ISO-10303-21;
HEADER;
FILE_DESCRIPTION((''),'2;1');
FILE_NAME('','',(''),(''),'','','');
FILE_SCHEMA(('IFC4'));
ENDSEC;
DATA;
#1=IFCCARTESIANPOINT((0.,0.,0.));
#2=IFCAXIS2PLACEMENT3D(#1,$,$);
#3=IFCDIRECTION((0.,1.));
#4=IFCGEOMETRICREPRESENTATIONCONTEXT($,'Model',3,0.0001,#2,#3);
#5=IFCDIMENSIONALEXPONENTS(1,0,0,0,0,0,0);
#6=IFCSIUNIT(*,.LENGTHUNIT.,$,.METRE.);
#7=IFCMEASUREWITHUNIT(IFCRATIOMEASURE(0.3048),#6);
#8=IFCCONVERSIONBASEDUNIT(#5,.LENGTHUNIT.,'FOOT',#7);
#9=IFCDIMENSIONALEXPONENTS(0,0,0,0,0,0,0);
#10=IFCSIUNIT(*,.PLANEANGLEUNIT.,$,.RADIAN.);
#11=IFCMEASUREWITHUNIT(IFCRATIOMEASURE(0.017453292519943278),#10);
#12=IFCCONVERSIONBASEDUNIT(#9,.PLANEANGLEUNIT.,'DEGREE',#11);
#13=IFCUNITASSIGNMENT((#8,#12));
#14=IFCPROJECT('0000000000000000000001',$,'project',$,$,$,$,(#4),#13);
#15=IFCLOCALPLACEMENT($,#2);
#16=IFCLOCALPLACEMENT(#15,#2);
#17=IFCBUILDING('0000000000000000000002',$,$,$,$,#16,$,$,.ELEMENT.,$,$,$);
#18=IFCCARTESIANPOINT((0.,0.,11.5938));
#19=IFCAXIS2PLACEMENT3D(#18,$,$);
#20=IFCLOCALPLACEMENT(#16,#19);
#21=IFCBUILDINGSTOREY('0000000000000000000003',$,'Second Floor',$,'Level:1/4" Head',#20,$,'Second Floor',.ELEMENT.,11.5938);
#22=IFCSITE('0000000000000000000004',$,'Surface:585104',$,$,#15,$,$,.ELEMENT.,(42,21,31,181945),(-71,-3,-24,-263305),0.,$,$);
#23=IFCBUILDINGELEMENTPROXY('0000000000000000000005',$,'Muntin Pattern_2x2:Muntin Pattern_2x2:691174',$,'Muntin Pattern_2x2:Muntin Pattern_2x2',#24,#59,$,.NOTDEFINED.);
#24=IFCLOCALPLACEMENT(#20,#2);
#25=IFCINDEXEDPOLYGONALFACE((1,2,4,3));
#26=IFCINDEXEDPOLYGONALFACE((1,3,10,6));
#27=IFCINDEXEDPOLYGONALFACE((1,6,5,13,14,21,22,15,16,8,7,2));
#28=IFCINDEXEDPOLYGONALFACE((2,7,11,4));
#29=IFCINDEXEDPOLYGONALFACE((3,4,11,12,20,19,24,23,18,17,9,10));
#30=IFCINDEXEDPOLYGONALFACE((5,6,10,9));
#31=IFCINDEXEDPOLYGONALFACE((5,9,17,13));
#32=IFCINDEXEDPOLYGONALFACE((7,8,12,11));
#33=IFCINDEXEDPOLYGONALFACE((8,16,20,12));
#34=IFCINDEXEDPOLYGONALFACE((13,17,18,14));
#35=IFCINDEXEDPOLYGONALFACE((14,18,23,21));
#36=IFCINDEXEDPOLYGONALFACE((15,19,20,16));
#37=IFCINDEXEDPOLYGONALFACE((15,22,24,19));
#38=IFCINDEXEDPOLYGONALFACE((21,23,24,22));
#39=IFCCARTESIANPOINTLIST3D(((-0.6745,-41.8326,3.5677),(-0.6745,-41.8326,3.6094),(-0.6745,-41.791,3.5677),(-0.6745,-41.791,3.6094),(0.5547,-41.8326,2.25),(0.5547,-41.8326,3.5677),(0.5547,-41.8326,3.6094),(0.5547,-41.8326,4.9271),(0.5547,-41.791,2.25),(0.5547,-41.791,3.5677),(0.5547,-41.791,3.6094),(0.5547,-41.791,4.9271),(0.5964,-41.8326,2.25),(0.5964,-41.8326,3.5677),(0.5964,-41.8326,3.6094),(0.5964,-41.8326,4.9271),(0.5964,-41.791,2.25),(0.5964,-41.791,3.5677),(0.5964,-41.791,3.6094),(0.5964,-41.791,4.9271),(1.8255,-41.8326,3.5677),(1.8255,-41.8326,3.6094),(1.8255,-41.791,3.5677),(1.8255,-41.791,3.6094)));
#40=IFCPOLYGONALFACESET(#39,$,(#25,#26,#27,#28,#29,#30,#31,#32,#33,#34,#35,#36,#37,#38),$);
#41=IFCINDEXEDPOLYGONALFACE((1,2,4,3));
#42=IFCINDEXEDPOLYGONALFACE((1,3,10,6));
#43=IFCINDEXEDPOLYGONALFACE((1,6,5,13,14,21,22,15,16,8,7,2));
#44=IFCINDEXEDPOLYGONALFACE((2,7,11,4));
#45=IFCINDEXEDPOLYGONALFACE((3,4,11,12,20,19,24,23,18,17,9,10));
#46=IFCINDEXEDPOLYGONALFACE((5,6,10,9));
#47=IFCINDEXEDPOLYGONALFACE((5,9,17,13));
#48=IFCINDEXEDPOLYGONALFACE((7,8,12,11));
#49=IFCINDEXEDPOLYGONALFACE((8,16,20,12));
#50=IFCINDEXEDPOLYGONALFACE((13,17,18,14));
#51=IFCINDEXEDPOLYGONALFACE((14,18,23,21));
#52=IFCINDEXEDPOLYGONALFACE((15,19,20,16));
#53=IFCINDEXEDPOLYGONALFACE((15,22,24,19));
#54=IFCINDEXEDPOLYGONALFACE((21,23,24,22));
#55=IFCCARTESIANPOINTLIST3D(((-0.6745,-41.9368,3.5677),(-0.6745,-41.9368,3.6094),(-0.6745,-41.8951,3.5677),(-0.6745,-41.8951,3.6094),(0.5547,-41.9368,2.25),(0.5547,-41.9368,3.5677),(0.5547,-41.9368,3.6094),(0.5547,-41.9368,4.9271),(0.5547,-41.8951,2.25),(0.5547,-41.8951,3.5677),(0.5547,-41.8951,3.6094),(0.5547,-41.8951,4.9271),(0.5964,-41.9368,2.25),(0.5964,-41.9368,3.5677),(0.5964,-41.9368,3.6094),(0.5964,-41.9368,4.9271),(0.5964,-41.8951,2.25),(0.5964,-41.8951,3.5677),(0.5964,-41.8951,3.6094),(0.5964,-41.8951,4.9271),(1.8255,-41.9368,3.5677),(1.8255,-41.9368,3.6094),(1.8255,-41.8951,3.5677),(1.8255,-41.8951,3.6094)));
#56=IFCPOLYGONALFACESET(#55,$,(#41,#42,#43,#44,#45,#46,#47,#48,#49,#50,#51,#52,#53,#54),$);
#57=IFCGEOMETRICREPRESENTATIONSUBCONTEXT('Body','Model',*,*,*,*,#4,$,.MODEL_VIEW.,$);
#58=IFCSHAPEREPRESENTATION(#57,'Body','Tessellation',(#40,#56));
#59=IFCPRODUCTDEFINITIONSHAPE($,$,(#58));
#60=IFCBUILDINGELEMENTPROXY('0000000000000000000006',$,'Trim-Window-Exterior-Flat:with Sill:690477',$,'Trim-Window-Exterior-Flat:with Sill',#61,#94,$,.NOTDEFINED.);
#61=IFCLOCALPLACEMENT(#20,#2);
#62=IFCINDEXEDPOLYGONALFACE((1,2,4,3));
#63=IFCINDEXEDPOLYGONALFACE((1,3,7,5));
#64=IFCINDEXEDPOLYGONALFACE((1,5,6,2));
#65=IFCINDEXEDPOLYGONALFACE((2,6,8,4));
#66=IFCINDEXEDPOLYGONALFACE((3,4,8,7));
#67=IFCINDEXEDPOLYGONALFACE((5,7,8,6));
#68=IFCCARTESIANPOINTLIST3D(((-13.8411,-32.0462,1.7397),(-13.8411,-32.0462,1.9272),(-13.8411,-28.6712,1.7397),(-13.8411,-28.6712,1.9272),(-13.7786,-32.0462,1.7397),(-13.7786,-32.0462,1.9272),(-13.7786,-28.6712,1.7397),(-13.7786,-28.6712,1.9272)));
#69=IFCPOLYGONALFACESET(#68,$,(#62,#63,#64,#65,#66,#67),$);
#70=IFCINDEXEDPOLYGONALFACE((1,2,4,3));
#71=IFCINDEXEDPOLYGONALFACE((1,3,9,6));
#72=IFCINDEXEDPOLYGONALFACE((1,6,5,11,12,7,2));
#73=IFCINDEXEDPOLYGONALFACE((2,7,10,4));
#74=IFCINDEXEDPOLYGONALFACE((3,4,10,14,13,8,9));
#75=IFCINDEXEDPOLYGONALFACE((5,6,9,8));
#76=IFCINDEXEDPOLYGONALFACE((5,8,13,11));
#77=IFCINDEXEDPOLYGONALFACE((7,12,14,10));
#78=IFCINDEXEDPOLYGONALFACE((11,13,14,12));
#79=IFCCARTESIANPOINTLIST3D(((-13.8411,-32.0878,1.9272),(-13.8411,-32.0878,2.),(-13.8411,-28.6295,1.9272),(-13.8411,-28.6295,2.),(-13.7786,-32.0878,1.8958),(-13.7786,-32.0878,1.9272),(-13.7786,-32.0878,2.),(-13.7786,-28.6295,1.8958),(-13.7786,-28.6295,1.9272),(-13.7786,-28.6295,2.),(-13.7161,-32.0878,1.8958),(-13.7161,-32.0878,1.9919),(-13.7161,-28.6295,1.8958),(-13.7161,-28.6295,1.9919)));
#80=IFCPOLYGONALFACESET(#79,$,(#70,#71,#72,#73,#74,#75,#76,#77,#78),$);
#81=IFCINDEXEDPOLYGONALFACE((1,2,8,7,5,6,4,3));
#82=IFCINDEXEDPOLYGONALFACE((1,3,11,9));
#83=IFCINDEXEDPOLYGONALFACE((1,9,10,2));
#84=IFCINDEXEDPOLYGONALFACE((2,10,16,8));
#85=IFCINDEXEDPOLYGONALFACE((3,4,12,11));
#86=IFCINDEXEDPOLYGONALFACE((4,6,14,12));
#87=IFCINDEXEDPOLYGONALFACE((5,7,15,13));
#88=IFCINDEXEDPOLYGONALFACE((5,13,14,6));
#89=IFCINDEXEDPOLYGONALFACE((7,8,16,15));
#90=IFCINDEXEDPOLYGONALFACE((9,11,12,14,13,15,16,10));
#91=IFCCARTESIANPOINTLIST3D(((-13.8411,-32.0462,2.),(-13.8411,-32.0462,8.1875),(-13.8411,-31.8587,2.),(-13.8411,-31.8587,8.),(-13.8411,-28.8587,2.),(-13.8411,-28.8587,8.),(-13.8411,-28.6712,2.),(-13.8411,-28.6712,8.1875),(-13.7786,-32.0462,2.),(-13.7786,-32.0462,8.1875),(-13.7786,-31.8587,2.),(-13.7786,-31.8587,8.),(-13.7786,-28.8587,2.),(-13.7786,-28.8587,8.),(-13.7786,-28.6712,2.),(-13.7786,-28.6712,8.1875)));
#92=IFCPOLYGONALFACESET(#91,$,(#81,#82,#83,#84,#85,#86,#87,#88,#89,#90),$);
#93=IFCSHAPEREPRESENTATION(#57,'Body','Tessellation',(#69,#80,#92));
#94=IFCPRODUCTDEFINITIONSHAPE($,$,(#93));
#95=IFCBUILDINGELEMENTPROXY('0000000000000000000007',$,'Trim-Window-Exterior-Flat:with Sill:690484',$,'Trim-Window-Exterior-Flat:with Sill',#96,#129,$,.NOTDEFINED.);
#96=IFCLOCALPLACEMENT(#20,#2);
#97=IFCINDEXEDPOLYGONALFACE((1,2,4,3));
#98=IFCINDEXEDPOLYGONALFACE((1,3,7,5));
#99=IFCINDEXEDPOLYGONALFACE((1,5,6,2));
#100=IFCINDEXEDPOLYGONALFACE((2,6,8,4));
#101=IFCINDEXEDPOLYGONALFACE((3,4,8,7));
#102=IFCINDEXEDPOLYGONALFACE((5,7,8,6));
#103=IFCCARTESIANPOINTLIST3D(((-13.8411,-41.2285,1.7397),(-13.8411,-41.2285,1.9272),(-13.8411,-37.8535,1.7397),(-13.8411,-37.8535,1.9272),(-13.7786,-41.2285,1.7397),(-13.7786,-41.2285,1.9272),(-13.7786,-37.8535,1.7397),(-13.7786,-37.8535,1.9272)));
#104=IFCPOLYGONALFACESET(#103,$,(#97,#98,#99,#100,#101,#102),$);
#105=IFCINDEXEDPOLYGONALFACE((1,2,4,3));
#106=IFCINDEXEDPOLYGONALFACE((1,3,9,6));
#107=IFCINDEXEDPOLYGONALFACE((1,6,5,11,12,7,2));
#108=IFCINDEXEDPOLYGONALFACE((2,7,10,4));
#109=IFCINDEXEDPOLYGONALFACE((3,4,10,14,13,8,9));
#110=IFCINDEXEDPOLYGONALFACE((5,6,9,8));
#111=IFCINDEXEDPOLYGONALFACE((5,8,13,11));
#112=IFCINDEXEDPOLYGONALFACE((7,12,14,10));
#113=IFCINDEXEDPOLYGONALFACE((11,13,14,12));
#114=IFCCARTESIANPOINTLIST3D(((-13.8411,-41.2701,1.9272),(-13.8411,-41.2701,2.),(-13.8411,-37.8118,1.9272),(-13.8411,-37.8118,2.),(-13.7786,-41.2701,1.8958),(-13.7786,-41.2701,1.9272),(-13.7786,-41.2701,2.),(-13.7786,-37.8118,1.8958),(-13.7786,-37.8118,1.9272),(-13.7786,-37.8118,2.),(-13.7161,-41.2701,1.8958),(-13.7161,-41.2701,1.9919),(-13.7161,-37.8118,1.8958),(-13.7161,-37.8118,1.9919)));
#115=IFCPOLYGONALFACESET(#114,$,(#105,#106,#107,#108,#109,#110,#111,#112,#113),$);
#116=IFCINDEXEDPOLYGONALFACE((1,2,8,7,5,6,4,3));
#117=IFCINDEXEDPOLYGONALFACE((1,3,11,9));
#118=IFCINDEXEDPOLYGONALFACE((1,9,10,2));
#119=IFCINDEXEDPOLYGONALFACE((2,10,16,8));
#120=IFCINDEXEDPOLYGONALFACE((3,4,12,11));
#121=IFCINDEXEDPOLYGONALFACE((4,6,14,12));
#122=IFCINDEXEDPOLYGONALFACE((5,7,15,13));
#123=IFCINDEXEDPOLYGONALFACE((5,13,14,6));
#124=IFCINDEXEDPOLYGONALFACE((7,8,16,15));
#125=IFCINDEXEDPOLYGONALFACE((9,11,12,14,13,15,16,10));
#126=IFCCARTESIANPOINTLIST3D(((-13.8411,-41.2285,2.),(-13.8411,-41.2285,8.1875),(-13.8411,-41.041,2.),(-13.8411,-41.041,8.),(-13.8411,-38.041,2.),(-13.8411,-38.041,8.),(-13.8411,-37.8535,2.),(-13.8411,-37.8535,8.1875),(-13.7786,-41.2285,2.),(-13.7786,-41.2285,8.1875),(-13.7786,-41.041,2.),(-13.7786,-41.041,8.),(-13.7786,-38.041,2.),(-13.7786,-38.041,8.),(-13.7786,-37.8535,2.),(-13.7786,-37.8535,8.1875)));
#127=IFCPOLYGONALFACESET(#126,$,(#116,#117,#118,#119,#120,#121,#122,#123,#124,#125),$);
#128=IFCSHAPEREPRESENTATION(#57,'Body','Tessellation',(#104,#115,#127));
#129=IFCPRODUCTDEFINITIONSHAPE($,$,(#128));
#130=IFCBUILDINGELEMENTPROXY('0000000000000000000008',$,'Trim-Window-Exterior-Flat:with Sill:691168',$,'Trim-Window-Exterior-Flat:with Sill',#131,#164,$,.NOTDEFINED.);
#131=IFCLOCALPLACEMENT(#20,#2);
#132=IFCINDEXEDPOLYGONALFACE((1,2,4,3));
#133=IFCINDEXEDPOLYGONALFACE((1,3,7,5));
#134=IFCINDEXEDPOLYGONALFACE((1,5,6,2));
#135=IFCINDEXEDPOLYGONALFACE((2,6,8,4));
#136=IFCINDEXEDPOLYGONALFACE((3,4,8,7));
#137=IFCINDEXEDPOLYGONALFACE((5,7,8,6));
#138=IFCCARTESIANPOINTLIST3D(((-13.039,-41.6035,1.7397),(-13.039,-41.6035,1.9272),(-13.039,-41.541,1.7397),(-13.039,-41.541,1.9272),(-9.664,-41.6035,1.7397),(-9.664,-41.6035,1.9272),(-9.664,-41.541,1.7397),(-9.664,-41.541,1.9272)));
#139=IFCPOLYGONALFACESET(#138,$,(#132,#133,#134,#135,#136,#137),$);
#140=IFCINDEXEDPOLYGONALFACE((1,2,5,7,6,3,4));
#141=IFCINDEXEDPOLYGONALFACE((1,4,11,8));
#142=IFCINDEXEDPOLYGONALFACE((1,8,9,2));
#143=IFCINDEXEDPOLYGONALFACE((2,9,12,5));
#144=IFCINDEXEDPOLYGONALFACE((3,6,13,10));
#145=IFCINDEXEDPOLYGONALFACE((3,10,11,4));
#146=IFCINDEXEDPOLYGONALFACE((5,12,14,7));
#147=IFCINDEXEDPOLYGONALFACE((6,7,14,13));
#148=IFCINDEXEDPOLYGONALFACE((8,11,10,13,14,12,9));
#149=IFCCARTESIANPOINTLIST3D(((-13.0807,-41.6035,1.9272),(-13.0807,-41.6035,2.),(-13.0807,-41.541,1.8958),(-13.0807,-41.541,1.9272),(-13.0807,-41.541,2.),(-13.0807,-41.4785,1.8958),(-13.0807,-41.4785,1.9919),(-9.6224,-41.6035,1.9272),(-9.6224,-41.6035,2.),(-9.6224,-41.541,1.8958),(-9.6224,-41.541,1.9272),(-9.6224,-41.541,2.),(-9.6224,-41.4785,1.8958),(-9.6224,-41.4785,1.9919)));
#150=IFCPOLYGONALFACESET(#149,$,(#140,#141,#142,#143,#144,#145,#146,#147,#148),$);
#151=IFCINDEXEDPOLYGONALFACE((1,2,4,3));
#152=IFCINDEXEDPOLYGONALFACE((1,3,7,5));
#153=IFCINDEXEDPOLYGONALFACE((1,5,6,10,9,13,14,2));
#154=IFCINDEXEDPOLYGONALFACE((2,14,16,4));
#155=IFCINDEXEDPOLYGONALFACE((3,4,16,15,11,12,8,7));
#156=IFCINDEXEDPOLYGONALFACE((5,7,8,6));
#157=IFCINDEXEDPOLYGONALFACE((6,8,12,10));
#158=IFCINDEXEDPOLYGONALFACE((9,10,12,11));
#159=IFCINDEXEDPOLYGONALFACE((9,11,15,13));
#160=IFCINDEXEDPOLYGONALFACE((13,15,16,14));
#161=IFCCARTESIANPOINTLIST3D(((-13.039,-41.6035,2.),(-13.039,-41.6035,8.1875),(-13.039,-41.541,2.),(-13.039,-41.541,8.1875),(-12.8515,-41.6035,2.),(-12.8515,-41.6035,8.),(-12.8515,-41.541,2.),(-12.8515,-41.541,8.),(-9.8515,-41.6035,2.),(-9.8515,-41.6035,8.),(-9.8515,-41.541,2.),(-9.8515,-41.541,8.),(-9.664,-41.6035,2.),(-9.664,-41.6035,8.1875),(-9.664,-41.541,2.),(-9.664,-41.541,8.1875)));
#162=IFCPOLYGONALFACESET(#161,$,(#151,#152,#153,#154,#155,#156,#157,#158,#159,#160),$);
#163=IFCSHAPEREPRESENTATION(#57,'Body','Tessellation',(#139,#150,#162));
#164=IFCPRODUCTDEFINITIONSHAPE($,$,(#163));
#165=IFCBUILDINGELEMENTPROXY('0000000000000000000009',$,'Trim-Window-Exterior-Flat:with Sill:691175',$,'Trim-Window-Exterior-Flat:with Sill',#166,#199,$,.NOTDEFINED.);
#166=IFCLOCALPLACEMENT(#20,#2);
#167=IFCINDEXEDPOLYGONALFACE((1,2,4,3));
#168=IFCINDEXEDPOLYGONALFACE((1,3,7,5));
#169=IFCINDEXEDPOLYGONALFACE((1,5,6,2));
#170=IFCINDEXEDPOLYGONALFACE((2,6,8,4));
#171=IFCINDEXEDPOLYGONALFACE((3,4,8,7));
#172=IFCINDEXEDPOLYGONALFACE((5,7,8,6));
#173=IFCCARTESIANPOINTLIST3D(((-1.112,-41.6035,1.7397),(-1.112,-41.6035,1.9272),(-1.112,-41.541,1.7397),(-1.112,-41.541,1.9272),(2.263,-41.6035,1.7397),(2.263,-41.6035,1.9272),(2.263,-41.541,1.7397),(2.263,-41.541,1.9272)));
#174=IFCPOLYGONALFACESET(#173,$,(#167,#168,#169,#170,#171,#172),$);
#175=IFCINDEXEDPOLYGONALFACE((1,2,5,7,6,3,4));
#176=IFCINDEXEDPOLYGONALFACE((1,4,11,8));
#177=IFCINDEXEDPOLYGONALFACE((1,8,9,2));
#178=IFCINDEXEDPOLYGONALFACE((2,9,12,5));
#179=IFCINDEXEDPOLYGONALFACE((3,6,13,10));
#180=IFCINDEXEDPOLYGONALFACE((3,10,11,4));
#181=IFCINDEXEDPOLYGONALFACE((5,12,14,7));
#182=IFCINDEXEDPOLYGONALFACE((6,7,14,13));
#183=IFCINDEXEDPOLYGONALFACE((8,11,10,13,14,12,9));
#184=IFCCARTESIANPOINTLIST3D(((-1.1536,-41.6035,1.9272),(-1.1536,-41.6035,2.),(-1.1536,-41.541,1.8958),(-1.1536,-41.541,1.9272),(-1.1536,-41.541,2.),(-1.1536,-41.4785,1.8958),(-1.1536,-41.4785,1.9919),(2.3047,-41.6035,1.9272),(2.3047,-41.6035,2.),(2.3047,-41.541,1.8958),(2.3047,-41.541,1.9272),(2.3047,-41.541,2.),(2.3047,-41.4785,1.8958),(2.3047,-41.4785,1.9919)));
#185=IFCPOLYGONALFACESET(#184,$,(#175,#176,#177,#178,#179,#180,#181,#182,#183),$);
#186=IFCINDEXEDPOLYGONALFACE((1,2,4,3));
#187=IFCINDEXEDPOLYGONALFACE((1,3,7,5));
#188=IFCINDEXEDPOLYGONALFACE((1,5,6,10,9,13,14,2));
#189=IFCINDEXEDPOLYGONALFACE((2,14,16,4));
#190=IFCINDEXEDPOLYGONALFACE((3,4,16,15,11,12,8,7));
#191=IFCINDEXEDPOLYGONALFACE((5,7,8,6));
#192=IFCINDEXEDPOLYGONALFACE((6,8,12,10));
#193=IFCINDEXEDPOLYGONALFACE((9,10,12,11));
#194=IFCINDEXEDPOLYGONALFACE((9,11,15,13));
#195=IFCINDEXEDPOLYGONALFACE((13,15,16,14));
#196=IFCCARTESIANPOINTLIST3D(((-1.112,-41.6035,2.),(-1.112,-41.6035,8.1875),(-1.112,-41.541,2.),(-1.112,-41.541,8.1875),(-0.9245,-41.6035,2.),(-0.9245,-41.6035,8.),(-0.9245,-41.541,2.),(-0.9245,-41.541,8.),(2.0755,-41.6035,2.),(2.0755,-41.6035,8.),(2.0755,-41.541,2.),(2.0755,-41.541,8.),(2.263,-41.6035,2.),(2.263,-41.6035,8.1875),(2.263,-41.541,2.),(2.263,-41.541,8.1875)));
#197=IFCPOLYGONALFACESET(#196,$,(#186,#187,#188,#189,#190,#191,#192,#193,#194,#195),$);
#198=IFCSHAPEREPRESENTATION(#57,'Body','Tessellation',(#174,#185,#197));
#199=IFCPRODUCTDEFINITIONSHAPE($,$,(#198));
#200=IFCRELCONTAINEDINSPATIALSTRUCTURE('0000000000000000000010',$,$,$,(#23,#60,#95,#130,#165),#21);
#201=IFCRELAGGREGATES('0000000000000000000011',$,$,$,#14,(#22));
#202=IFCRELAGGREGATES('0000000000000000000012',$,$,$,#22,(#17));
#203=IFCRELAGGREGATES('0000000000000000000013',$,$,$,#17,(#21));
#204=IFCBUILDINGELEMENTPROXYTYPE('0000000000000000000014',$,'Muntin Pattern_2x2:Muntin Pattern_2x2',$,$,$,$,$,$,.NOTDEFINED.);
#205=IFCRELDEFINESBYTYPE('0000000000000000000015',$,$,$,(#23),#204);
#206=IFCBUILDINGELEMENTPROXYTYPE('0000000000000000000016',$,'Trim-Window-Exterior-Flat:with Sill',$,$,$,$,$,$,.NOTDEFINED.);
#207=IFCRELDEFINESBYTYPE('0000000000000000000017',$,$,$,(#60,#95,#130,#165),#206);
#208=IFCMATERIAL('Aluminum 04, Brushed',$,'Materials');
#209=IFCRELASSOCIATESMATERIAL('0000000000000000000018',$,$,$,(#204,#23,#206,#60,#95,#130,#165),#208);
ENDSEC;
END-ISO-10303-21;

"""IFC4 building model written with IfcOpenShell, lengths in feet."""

from ifc_helpers import new_model, entity, si_unit, converted_unit, direction, frame, origin, place, context, subcontext, project, spatial, indexed_curve, outline, extrude, source, transform, mapped, material, type_object, type_shapes, element, save


model = new_model("IFC4")

# Units and contexts
model_context = context("Model", 3, precision=0.0001, world=origin(), true_north=direction((0.0, 1.0)))
body_context = subcontext(model_context, "Body", "Model", "MODEL_VIEW")
ifc_project = project(units=[converted_unit("LENGTHUNIT", "FOOT", entity("IfcRatioMeasure", 0.3048), si_unit("LENGTHUNIT", "METRE"), dimensions=[1, 0, 0, 0, 0, 0, 0]), converted_unit("PLANEANGLEUNIT", "DEGREE", entity("IfcRatioMeasure", 0.017453292519943278), si_unit("PLANEANGLEUNIT", "RADIAN"), dimensions=[0, 0, 0, 0, 0, 0, 0])], contexts=[model_context])

# Site, building, storey
site_placement = place(None, origin())
site = spatial("IfcSite", under=ifc_project, at=site_placement, Name="Surface:585104", CompositionType="ELEMENT", RefLatitude=(42, 21, 31, 181945), RefLongitude=(-71, -3, -24, -263305), RefElevation=0.0)
building_placement = place(site_placement, origin())
building = spatial("IfcBuilding", under=site, at=building_placement, CompositionType="ELEMENT")
storey_placement = place(building_placement, frame((0.0, 0.0, 11.5938)))
storey = spatial("IfcBuildingStorey", under=building, at=storey_placement, Name="Second Floor", ObjectType="Level:1/4\" Head", LongName="Second Floor", CompositionType="ELEMENT", Elevation=11.5938)

# Building element proxies
ifc_material_1 = material(Name="Aluminum 04, Brushed", Category="Materials")
building_element_proxy_type_1 = type_object("IfcBuildingElementProxyType", Name="Muntin Pattern_2x2:Muntin Pattern_2x2", PredefinedType="NOTDEFINED", material=ifc_material_1)
shared_shape_1 = source(origin(), body_context, "Body", "SweptSolid", [
    extrude(outline(indexed_curve([(0.0208, -0.0208), (1.3385, -0.0208), (1.3385, 0.0208), (0.0208, 0.0208), (0.0208, 1.25), (-0.0208, 1.25), (-0.0208, 0.0208), (-1.3385, 0.0208), (-1.3385, -0.0208), (-0.0208, -0.0208), (-0.0208, -1.25), (0.0208, -1.25), (0.0208, -0.0208)], self_intersect=False)), frame((0.0, -0.0729, 1.3385), z_axis=(0.0, 1.0, 0.0), x_axis=(0.0, 0.0, 1.0)), (0.0, 0.0, 1.0), 0.0417),
    extrude(outline(indexed_curve([(0.0208, -0.0208), (1.3385, -0.0208), (1.3385, 0.0208), (0.0208, 0.0208), (0.0208, 1.25), (-0.0208, 1.25), (-0.0208, 0.0208), (-1.3385, 0.0208), (-1.3385, -0.0208), (-0.0208, -0.0208), (-0.0208, -1.25), (0.0208, -1.25), (0.0208, -0.0208)], self_intersect=False)), frame((0.0, 0.0313, 1.3385), z_axis=(0.0, 1.0, 0.0), x_axis=(0.0, 0.0, 1.0)), (0.0, 0.0, 1.0), 0.0417),
])
type_shapes(building_element_proxy_type_1, [shared_shape_1])
for number, where, z_axis, x_axis, name in (
    (1, (0.5755, -41.8639, 2.25), (0.0, 0.0, 1.0), (-1.0, 0.0, 0.0), "Muntin Pattern_2x2:Muntin Pattern_2x2:691174"),
):
    element("IfcBuildingElementProxy", number, at=place(storey_placement, frame(where, z_axis=z_axis, x_axis=x_axis)), inside=storey, type_object=building_element_proxy_type_1, material=ifc_material_1, Name=name, ObjectType="Muntin Pattern_2x2:Muntin Pattern_2x2", PredefinedType="NOTDEFINED", context=body_context, shape_type="MappedRepresentation", body=[
        mapped(shared_shape_1, transform((0.0, 0.0, 0.0), scale=1.0)),
    ])
building_element_proxy_type_2 = type_object("IfcBuildingElementProxyType", Name="Trim-Window-Exterior-Flat:with Sill", PredefinedType="NOTDEFINED", material=ifc_material_1)
shared_shape_2 = source(origin(), body_context, "Body", "SweptSolid", [
    extrude(outline(indexed_curve([(-0.0938, -1.6875), (0.0938, -1.6875), (0.0938, 1.6875), (-0.0938, 1.6875), (-0.0938, -1.6875)], self_intersect=False)), frame((0.0, 6.1665, 0.0), z_axis=(0.0, 0.0, 1.0), x_axis=(0.0, 1.0, 0.0)), (0.0, 0.0, 1.0), 0.0625),
    extrude(outline(indexed_curve([(-0.0525, -0.0625), (0.0436, -0.0625), (0.0517, 0.0), (0.0517, 0.0625), (-0.0211, 0.0625), (-0.0211, 0.0), (-0.0525, 0.0), (-0.0525, -0.0625)], self_intersect=False)), frame((-1.7292, 6.0517, 0.0625), z_axis=(1.0, 0.0, 0.0), x_axis=(0.0, -1.0, 0.0)), (0.0, 0.0, 1.0), 3.4583),
    extrude(outline(indexed_curve([(-1.6875, -3.1406), (1.6875, -3.1406), (1.6875, 3.0469), (1.5, 3.0469), (1.5, -2.9531), (-1.5, -2.9531), (-1.5, 3.0469), (-1.6875, 3.0469), (-1.6875, -3.1406)], self_intersect=False)), frame((0.0, 2.9531, 0.0)), (0.0, 0.0, 1.0), 0.0625),
])
type_shapes(building_element_proxy_type_2, [shared_shape_2])
for number, where, z_axis, x_axis, name in (
    (2, (-13.8411, -30.3587, 8.0), (1.0, 0.0, 0.0), (0.0, -1.0, 0.0), "Trim-Window-Exterior-Flat:with Sill:690477"),
    (3, (-13.8411, -39.541, 8.0), (1.0, 0.0, 0.0), (0.0, -1.0, 0.0), "Trim-Window-Exterior-Flat:with Sill:690484"),
    (4, (-11.3515, -41.6035, 8.0), (0.0, 1.0, 0.0), (1.0, 0.0, 0.0), "Trim-Window-Exterior-Flat:with Sill:691168"),
    (5, (0.5755, -41.6035, 8.0), (0.0, 1.0, 0.0), (1.0, 0.0, 0.0), "Trim-Window-Exterior-Flat:with Sill:691175"),
):
    element("IfcBuildingElementProxy", number, at=place(storey_placement, frame(where, z_axis=z_axis, x_axis=x_axis)), inside=storey, type_object=building_element_proxy_type_2, material=ifc_material_1, Name=name, ObjectType="Trim-Window-Exterior-Flat:with Sill", PredefinedType="NOTDEFINED", context=body_context, shape_type="MappedRepresentation", body=[
        mapped(shared_shape_2, transform((0.0, 0.0, 0.0), scale=1.0)),
    ])

save(model, "model.ifc")
